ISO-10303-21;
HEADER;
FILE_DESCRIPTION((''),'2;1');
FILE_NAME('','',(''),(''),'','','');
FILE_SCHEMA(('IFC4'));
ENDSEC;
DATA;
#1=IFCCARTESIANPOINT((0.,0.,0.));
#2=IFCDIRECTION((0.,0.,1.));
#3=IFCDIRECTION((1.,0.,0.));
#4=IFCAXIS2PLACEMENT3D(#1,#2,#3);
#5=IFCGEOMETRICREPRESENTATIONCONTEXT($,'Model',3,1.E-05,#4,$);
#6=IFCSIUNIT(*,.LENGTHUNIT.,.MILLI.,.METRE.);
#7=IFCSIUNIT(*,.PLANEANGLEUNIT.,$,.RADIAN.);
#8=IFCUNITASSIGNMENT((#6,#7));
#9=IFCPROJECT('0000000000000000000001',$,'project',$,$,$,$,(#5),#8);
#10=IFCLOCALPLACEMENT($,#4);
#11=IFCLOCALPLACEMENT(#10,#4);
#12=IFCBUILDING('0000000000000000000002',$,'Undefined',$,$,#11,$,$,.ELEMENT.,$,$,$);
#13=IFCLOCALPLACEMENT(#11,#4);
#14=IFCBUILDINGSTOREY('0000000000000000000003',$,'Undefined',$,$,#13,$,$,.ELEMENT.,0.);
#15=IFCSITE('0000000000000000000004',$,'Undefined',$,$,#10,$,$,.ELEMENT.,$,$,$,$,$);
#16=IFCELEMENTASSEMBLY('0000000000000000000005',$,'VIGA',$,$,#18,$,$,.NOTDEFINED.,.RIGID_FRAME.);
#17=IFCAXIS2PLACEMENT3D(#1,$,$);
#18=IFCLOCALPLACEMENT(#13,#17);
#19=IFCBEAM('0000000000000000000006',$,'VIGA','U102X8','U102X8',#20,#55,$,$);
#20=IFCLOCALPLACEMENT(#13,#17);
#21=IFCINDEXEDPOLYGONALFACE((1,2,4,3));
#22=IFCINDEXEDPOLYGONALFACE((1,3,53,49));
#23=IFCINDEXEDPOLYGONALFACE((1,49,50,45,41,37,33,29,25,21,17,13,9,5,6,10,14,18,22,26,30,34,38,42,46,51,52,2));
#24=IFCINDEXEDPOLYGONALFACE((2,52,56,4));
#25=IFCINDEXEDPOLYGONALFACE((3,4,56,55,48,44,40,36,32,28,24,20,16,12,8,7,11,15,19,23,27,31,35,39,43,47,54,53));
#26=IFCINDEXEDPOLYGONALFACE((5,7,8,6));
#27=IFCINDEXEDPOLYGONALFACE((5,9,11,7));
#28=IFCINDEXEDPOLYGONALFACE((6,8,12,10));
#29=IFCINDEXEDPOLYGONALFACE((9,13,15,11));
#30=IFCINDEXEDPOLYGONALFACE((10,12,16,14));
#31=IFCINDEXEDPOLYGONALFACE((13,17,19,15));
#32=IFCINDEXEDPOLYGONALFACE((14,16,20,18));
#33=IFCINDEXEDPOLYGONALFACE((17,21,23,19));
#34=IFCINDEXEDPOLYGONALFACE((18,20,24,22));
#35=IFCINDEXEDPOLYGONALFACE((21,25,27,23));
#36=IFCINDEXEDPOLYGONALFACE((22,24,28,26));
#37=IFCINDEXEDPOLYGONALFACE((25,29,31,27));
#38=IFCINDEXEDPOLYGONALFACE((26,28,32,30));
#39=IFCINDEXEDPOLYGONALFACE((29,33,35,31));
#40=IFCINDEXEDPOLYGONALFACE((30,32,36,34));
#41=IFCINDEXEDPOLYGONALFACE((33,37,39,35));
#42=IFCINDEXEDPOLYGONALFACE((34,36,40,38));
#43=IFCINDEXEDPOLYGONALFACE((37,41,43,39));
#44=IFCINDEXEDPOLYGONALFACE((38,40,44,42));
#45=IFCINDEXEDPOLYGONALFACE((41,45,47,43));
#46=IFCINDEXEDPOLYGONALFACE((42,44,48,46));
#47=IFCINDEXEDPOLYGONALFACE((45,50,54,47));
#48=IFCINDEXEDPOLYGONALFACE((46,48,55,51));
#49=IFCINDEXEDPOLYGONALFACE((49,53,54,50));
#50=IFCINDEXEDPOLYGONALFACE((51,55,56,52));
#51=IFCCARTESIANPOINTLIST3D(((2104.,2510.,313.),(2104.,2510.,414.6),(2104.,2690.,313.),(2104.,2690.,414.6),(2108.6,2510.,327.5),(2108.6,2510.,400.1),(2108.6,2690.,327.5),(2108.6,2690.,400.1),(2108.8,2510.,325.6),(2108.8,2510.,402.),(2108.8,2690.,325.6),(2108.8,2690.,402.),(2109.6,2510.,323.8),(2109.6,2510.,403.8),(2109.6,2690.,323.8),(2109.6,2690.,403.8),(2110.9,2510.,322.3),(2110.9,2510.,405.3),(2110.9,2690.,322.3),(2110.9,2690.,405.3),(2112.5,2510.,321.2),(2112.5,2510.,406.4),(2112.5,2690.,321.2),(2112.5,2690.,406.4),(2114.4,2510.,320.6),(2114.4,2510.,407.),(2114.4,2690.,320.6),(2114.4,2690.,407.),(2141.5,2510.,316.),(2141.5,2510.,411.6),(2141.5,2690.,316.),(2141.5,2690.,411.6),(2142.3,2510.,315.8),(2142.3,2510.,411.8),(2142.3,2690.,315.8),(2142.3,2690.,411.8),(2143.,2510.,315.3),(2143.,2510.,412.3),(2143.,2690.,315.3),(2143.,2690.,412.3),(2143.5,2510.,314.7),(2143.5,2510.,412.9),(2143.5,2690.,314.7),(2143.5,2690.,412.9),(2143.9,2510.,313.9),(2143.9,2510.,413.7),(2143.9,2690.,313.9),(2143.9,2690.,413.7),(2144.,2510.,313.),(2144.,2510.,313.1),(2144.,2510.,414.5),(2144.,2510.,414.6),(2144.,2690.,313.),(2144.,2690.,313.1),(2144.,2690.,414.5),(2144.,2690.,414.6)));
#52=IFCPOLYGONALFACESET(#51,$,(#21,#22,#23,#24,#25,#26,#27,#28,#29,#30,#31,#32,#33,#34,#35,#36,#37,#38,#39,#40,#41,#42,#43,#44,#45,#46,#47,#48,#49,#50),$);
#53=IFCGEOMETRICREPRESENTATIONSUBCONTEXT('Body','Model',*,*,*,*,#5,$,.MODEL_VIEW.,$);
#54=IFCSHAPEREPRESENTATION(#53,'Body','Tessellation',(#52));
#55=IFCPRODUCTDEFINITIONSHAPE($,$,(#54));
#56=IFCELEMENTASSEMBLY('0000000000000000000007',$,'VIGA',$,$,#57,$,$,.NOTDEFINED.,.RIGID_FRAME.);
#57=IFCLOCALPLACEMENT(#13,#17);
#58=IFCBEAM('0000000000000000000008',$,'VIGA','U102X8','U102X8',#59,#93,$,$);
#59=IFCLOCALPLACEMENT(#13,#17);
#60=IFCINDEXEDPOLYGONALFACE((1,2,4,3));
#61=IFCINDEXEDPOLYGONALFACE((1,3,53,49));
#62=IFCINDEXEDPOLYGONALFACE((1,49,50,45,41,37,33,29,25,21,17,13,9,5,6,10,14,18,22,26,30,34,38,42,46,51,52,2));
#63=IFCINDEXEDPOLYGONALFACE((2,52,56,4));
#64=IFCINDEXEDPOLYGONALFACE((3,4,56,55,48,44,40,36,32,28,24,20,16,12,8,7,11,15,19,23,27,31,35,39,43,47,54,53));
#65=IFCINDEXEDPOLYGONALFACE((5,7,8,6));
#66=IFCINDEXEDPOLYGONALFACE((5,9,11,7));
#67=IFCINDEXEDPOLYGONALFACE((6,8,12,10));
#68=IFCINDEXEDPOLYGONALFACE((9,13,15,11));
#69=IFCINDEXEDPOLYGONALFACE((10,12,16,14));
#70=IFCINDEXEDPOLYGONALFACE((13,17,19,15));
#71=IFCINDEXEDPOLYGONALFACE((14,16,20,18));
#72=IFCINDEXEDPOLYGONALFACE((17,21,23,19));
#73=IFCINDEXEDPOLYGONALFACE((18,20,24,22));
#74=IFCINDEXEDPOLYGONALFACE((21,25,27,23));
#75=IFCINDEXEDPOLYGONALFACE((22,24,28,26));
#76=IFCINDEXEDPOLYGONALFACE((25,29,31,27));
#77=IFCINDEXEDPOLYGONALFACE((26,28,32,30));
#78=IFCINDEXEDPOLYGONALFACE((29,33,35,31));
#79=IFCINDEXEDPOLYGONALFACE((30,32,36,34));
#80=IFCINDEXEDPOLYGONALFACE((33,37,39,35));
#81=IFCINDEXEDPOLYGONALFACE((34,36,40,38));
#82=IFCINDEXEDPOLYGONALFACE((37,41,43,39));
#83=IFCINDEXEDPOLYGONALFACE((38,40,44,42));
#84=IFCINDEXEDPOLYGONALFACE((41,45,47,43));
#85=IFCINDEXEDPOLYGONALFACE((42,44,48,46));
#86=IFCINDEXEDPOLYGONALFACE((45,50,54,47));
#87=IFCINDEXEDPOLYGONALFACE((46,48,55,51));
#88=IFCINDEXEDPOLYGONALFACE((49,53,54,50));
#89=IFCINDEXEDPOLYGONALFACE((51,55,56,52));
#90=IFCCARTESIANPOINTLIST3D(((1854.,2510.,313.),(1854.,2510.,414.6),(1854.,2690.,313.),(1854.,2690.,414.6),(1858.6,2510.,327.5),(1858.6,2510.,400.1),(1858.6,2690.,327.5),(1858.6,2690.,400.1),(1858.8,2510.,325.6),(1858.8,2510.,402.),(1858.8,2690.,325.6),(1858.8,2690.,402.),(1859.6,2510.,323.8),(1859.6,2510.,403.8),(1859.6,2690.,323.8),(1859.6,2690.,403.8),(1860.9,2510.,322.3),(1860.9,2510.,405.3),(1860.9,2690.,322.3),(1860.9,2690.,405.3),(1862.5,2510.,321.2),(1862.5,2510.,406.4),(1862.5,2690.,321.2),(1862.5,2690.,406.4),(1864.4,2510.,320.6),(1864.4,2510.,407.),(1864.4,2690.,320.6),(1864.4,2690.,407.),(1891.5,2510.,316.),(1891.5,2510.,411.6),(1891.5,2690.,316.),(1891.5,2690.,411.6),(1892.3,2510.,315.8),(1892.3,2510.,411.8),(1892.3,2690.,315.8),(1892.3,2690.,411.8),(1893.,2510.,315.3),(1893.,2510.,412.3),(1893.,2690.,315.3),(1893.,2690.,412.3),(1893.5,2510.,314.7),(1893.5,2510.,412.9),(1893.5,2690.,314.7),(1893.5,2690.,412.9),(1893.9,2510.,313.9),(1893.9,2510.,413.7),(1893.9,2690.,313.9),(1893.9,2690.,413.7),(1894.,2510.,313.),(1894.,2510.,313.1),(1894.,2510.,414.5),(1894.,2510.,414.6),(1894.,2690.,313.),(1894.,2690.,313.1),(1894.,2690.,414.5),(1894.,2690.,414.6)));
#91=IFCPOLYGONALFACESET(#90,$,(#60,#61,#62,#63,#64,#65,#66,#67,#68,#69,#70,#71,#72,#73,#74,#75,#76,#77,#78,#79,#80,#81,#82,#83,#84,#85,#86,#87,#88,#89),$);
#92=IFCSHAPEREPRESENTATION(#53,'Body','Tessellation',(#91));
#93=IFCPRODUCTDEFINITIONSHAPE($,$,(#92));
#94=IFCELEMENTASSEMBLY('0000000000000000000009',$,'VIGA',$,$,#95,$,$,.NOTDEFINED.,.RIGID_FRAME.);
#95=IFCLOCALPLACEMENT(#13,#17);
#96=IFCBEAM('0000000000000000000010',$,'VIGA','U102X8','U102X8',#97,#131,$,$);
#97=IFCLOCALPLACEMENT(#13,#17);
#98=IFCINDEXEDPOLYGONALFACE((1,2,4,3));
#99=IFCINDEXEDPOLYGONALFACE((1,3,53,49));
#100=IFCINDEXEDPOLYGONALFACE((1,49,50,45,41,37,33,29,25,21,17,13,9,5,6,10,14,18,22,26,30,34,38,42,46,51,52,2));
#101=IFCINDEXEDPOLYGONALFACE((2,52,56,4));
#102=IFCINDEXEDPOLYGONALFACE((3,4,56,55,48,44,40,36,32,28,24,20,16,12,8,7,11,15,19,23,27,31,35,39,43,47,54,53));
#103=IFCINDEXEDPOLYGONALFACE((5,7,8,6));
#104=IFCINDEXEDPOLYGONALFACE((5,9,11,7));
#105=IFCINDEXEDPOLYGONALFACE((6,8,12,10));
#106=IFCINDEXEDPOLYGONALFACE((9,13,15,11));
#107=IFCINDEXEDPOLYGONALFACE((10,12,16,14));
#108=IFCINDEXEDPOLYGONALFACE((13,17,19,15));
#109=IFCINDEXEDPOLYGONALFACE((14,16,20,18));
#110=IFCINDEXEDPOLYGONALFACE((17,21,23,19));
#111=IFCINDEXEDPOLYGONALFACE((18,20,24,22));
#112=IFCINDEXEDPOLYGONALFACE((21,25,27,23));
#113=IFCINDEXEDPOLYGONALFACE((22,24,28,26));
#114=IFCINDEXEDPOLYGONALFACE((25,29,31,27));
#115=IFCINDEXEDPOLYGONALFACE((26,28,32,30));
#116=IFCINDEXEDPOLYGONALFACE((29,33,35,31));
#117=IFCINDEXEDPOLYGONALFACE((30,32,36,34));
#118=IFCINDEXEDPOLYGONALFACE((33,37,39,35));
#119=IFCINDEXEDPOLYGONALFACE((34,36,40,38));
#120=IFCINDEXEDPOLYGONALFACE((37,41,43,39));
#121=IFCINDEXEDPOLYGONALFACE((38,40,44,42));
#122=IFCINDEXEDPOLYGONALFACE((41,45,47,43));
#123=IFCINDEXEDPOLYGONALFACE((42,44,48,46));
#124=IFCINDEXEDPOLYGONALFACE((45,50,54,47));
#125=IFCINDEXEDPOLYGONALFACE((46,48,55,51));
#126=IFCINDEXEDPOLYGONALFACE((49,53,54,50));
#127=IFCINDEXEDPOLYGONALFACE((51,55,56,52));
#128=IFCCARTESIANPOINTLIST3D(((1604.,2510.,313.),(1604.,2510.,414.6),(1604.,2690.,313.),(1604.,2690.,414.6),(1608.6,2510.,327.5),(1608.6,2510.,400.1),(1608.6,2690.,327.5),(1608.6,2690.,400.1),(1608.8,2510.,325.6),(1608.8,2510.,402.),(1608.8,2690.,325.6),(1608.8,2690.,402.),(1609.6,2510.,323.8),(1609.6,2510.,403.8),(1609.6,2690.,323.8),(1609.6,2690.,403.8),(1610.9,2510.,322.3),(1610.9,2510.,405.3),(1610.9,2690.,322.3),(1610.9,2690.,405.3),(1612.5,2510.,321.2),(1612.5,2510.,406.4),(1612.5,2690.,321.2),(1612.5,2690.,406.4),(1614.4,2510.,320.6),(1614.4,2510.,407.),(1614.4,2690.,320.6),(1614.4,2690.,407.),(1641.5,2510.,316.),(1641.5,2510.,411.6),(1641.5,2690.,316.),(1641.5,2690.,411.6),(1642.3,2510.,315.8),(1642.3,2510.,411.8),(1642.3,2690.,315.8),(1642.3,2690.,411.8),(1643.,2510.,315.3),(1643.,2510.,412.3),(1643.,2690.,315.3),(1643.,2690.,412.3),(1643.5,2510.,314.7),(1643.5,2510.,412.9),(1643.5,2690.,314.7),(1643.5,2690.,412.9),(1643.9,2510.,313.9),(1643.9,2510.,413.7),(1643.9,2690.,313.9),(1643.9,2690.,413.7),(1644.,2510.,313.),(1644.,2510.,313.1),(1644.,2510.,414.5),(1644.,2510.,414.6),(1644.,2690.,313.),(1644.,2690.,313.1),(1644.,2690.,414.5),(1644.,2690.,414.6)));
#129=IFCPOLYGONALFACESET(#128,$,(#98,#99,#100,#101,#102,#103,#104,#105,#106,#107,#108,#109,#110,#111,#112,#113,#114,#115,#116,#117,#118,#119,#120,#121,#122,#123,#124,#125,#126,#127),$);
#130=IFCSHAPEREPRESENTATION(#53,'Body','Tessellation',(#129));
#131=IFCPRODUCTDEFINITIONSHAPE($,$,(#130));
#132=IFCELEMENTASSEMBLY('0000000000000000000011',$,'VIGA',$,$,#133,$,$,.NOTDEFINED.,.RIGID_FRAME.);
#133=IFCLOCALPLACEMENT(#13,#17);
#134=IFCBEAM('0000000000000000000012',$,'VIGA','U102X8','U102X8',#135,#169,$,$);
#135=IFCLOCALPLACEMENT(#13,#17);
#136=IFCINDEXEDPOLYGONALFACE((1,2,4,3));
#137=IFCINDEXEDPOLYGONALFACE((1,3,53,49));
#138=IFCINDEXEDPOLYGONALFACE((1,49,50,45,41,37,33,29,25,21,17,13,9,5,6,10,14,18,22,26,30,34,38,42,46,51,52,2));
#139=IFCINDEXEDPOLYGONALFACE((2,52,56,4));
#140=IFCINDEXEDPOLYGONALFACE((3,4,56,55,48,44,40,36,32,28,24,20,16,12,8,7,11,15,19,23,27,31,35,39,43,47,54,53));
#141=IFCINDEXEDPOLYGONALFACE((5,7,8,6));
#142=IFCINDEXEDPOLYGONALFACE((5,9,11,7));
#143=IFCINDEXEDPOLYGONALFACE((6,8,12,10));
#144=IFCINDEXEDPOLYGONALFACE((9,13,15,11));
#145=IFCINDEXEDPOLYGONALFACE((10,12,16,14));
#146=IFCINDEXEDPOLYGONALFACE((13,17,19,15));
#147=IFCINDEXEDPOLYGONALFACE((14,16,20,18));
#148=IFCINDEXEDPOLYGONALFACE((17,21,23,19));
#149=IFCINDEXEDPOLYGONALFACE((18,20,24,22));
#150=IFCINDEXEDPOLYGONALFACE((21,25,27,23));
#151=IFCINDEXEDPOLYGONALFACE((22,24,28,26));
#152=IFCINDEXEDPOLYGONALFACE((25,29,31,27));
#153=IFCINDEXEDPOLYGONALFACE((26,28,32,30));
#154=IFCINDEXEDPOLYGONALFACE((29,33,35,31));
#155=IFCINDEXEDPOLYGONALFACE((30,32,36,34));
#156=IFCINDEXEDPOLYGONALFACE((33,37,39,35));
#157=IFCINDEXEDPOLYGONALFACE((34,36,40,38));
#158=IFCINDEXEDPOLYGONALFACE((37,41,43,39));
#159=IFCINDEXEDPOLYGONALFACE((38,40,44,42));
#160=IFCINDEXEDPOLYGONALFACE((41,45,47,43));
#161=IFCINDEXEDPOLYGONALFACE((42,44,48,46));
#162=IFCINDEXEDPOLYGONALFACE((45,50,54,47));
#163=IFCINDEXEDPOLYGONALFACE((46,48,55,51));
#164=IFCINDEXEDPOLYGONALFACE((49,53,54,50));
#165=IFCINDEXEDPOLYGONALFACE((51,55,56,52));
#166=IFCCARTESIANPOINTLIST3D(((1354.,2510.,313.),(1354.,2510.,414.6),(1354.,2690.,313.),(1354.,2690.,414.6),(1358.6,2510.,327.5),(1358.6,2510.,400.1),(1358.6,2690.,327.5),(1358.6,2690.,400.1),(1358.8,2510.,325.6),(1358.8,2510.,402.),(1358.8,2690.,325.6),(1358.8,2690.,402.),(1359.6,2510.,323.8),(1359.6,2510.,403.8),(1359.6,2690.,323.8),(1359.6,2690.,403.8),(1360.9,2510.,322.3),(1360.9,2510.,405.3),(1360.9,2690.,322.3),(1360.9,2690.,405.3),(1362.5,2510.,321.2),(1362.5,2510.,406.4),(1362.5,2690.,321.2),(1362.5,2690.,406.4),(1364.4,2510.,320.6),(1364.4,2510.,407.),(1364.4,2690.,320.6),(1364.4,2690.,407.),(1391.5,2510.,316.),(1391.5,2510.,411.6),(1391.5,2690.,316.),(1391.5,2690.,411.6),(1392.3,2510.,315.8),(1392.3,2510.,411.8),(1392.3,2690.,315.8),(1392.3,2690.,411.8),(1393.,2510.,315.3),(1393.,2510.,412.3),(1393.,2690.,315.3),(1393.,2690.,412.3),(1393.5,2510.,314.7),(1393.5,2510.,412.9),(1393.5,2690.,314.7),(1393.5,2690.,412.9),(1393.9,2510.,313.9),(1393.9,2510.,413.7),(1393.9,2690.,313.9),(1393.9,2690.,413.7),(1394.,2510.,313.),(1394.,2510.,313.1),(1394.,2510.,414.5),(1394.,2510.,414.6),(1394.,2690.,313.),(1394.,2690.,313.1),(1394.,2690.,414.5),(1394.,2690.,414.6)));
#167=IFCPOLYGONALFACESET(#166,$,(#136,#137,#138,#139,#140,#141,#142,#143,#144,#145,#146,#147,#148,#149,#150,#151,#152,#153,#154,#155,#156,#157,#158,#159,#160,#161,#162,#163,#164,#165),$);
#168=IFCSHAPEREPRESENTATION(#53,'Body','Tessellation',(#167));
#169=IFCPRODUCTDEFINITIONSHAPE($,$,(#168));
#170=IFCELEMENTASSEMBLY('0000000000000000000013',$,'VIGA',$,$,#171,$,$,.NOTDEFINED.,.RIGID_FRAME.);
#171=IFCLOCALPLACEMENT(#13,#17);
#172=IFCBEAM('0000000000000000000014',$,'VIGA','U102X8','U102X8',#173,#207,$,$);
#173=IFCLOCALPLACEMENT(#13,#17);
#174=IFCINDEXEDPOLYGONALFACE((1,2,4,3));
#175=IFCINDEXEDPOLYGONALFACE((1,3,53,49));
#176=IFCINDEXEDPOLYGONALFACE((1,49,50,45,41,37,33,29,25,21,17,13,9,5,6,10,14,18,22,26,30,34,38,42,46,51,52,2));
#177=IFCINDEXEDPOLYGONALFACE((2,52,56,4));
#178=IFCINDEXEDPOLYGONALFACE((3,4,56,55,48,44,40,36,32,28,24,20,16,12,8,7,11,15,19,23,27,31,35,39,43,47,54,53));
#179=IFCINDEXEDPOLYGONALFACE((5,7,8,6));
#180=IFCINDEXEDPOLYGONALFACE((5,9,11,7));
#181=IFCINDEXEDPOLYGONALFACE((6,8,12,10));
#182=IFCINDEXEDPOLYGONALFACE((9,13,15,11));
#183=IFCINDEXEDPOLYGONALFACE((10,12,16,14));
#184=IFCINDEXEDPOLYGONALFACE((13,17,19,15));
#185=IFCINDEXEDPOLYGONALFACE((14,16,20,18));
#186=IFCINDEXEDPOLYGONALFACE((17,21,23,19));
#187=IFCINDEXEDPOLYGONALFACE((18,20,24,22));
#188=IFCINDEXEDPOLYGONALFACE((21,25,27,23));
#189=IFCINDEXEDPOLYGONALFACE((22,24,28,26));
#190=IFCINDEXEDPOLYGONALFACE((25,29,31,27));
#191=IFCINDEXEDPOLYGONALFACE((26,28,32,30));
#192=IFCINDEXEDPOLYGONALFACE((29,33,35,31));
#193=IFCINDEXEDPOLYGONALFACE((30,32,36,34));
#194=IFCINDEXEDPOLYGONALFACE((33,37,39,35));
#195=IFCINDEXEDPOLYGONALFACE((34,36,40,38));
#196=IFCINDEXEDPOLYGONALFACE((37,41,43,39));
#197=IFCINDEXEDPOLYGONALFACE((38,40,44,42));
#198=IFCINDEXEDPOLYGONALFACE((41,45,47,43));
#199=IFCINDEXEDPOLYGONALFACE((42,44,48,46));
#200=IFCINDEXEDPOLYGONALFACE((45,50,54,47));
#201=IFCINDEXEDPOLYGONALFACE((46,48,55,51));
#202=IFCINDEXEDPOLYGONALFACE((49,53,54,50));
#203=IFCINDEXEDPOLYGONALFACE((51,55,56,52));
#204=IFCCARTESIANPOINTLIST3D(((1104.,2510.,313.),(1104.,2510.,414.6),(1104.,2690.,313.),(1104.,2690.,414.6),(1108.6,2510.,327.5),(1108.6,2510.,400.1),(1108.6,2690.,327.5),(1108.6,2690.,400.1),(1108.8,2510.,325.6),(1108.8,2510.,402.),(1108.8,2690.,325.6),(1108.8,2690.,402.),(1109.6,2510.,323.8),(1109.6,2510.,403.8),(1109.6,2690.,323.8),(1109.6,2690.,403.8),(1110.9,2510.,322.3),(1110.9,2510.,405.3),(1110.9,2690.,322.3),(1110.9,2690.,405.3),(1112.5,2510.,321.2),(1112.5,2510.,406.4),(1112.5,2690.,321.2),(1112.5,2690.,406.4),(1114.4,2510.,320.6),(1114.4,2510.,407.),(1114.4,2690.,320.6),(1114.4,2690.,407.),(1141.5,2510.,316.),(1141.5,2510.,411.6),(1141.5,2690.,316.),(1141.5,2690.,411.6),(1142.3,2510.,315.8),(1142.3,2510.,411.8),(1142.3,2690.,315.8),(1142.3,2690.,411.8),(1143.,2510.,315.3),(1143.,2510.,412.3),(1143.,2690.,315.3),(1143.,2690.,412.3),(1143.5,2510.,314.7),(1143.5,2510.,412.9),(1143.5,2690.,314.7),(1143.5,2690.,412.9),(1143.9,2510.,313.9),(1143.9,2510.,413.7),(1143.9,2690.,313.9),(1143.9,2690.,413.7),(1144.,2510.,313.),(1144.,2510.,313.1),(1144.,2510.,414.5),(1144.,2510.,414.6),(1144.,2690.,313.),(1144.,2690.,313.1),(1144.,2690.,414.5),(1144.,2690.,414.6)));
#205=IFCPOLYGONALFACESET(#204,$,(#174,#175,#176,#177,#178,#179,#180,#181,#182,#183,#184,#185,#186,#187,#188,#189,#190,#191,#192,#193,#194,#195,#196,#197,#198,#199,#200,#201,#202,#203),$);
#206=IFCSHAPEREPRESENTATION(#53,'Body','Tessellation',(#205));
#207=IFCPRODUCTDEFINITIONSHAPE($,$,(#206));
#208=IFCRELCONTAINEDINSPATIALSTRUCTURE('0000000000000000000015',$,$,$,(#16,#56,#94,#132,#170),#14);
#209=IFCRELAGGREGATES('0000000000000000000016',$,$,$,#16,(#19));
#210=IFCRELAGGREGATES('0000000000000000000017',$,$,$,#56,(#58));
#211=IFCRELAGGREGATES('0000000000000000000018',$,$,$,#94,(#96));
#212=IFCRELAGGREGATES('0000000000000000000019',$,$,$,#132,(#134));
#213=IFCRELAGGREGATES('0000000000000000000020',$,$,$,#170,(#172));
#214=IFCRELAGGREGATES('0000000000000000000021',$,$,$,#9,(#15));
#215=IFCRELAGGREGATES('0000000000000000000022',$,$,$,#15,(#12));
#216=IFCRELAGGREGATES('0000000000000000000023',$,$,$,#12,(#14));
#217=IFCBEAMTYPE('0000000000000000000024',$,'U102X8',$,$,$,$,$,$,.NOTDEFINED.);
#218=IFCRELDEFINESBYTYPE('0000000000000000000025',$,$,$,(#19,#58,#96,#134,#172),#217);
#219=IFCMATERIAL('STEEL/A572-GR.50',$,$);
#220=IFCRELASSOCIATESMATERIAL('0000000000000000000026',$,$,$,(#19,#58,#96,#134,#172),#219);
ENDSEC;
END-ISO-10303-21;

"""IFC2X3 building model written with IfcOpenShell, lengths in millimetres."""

from ifc_helpers import new_model, si_unit, frame, origin_with_axes, origin_2d_with_axis, place, context, subcontext, project, spatial, u_section, extrude, material, type_object, element, aggregate, save


model = new_model("IFC2X3")

# Units and contexts
model_context = context("Model", 3, precision=1e-05, world=origin_with_axes())
body_context = subcontext(model_context, "Body", "Model", "MODEL_VIEW")
ifc_project = project(units=[si_unit("LENGTHUNIT", "METRE", prefix="MILLI"), si_unit("PLANEANGLEUNIT", "RADIAN")], contexts=[model_context])

# Site, building, storey
site_placement = place(None, origin_with_axes())
site = spatial("IfcSite", under=ifc_project, at=site_placement, Name="Undefined", CompositionType="ELEMENT")
building_placement = place(site_placement, origin_with_axes())
building = spatial("IfcBuilding", under=site, at=building_placement, Name="Undefined", CompositionType="ELEMENT")
storey_placement = place(building_placement, origin_with_axes())
storey = spatial("IfcBuildingStorey", under=building, at=storey_placement, Name="Undefined", CompositionType="ELEMENT", Elevation=0.0)

# Element assemblies, beams
ifc_material_1 = material(Name="STEEL/A572-GR.50")
beam_type_1 = type_object("IfcBeamType", Name="U102X8", PredefinedType="NOTDEFINED")
assembly_1_placement = place(storey_placement, origin_with_axes())
assembly_1 = element("IfcElementAssembly", 1, at=assembly_1_placement, inside=storey, Name="VIGA", AssemblyPlace="NOTDEFINED", PredefinedType="RIGID_FRAME")
beam_1_placement = place(assembly_1_placement, frame((2124.0, 2510.0, 363.8), z_axis=(0.0, 0.0, 1.0), x_axis=(0.0, 1.0, 0.0)))
beam_1 = element("IfcBeam", 2, at=beam_1_placement, type_object=beam_type_1, material=ifc_material_1, Name="VIGA", Description="U102X8", ObjectType="U102X8", context=body_context, shape_type="SweptSolid", body=[
    extrude(u_section(Depth=101.6, FlangeWidth=40.0, WebThickness=4.6, FlangeThickness=6.0, FilletRadius=7.0, EdgeRadius=3.0, FlangeSlope=0.16839, at=origin_2d_with_axis()), frame((180.0, 0.0, 0.0), z_axis=(-1.0, 0.0, 0.0), x_axis=(0.0, -1.0, 0.0)), (0.0, 0.0, 1.0), 180.0),
])
aggregate(assembly_1, [beam_1])
assembly_2_placement = place(storey_placement, origin_with_axes())
assembly_2 = element("IfcElementAssembly", 3, at=assembly_2_placement, inside=storey, Name="VIGA", AssemblyPlace="NOTDEFINED", PredefinedType="RIGID_FRAME")
beam_2_placement = place(assembly_2_placement, frame((1874.0, 2510.0, 363.8), z_axis=(0.0, 0.0, 1.0), x_axis=(0.0, 1.0, 0.0)))
beam_2 = element("IfcBeam", 4, at=beam_2_placement, type_object=beam_type_1, material=ifc_material_1, Name="VIGA", Description="U102X8", ObjectType="U102X8", context=body_context, shape_type="SweptSolid", body=[
    extrude(u_section(Depth=101.6, FlangeWidth=40.0, WebThickness=4.6, FlangeThickness=6.0, FilletRadius=7.0, EdgeRadius=3.0, FlangeSlope=0.16839, at=origin_2d_with_axis()), frame((180.0, 0.0, 0.0), z_axis=(-1.0, 0.0, 0.0), x_axis=(0.0, -1.0, 0.0)), (0.0, 0.0, 1.0), 180.0),
])
aggregate(assembly_2, [beam_2])
assembly_3_placement = place(storey_placement, origin_with_axes())
assembly_3 = element("IfcElementAssembly", 5, at=assembly_3_placement, inside=storey, Name="VIGA", AssemblyPlace="NOTDEFINED", PredefinedType="RIGID_FRAME")
beam_3_placement = place(assembly_3_placement, frame((1624.0, 2510.0, 363.8), z_axis=(0.0, 0.0, 1.0), x_axis=(0.0, 1.0, 0.0)))
beam_3 = element("IfcBeam", 6, at=beam_3_placement, type_object=beam_type_1, material=ifc_material_1, Name="VIGA", Description="U102X8", ObjectType="U102X8", context=body_context, shape_type="SweptSolid", body=[
    extrude(u_section(Depth=101.6, FlangeWidth=40.0, WebThickness=4.6, FlangeThickness=6.0, FilletRadius=7.0, EdgeRadius=3.0, FlangeSlope=0.16839, at=origin_2d_with_axis()), frame((180.0, 0.0, 0.0), z_axis=(-1.0, 0.0, 0.0), x_axis=(0.0, -1.0, 0.0)), (0.0, 0.0, 1.0), 180.0),
])
aggregate(assembly_3, [beam_3])
assembly_4_placement = place(storey_placement, origin_with_axes())
assembly_4 = element("IfcElementAssembly", 7, at=assembly_4_placement, inside=storey, Name="VIGA", AssemblyPlace="NOTDEFINED", PredefinedType="RIGID_FRAME")
beam_4_placement = place(assembly_4_placement, frame((1374.0, 2510.0, 363.8), z_axis=(0.0, 0.0, 1.0), x_axis=(0.0, 1.0, 0.0)))
beam_4 = element("IfcBeam", 8, at=beam_4_placement, type_object=beam_type_1, material=ifc_material_1, Name="VIGA", Description="U102X8", ObjectType="U102X8", context=body_context, shape_type="SweptSolid", body=[
    extrude(u_section(Depth=101.6, FlangeWidth=40.0, WebThickness=4.6, FlangeThickness=6.0, FilletRadius=7.0, EdgeRadius=3.0, FlangeSlope=0.16839, at=origin_2d_with_axis()), frame((180.0, 0.0, 0.0), z_axis=(-1.0, 0.0, 0.0), x_axis=(0.0, -1.0, 0.0)), (0.0, 0.0, 1.0), 180.0),
])
aggregate(assembly_4, [beam_4])
assembly_5_placement = place(storey_placement, origin_with_axes())
assembly_5 = element("IfcElementAssembly", 9, at=assembly_5_placement, inside=storey, Name="VIGA", AssemblyPlace="NOTDEFINED", PredefinedType="RIGID_FRAME")
beam_5_placement = place(assembly_5_placement, frame((1124.0, 2510.0, 363.8), z_axis=(0.0, 0.0, 1.0), x_axis=(0.0, 1.0, 0.0)))
beam_5 = element("IfcBeam", 10, at=beam_5_placement, type_object=beam_type_1, material=ifc_material_1, Name="VIGA", Description="U102X8", ObjectType="U102X8", context=body_context, shape_type="SweptSolid", body=[
    extrude(u_section(Depth=101.6, FlangeWidth=40.0, WebThickness=4.6, FlangeThickness=6.0, FilletRadius=7.0, EdgeRadius=3.0, FlangeSlope=0.16839, at=origin_2d_with_axis()), frame((180.0, 0.0, 0.0), z_axis=(-1.0, 0.0, 0.0), x_axis=(0.0, -1.0, 0.0)), (0.0, 0.0, 1.0), 180.0),
])
aggregate(assembly_5, [beam_5])

save(model, "model.ifc")
